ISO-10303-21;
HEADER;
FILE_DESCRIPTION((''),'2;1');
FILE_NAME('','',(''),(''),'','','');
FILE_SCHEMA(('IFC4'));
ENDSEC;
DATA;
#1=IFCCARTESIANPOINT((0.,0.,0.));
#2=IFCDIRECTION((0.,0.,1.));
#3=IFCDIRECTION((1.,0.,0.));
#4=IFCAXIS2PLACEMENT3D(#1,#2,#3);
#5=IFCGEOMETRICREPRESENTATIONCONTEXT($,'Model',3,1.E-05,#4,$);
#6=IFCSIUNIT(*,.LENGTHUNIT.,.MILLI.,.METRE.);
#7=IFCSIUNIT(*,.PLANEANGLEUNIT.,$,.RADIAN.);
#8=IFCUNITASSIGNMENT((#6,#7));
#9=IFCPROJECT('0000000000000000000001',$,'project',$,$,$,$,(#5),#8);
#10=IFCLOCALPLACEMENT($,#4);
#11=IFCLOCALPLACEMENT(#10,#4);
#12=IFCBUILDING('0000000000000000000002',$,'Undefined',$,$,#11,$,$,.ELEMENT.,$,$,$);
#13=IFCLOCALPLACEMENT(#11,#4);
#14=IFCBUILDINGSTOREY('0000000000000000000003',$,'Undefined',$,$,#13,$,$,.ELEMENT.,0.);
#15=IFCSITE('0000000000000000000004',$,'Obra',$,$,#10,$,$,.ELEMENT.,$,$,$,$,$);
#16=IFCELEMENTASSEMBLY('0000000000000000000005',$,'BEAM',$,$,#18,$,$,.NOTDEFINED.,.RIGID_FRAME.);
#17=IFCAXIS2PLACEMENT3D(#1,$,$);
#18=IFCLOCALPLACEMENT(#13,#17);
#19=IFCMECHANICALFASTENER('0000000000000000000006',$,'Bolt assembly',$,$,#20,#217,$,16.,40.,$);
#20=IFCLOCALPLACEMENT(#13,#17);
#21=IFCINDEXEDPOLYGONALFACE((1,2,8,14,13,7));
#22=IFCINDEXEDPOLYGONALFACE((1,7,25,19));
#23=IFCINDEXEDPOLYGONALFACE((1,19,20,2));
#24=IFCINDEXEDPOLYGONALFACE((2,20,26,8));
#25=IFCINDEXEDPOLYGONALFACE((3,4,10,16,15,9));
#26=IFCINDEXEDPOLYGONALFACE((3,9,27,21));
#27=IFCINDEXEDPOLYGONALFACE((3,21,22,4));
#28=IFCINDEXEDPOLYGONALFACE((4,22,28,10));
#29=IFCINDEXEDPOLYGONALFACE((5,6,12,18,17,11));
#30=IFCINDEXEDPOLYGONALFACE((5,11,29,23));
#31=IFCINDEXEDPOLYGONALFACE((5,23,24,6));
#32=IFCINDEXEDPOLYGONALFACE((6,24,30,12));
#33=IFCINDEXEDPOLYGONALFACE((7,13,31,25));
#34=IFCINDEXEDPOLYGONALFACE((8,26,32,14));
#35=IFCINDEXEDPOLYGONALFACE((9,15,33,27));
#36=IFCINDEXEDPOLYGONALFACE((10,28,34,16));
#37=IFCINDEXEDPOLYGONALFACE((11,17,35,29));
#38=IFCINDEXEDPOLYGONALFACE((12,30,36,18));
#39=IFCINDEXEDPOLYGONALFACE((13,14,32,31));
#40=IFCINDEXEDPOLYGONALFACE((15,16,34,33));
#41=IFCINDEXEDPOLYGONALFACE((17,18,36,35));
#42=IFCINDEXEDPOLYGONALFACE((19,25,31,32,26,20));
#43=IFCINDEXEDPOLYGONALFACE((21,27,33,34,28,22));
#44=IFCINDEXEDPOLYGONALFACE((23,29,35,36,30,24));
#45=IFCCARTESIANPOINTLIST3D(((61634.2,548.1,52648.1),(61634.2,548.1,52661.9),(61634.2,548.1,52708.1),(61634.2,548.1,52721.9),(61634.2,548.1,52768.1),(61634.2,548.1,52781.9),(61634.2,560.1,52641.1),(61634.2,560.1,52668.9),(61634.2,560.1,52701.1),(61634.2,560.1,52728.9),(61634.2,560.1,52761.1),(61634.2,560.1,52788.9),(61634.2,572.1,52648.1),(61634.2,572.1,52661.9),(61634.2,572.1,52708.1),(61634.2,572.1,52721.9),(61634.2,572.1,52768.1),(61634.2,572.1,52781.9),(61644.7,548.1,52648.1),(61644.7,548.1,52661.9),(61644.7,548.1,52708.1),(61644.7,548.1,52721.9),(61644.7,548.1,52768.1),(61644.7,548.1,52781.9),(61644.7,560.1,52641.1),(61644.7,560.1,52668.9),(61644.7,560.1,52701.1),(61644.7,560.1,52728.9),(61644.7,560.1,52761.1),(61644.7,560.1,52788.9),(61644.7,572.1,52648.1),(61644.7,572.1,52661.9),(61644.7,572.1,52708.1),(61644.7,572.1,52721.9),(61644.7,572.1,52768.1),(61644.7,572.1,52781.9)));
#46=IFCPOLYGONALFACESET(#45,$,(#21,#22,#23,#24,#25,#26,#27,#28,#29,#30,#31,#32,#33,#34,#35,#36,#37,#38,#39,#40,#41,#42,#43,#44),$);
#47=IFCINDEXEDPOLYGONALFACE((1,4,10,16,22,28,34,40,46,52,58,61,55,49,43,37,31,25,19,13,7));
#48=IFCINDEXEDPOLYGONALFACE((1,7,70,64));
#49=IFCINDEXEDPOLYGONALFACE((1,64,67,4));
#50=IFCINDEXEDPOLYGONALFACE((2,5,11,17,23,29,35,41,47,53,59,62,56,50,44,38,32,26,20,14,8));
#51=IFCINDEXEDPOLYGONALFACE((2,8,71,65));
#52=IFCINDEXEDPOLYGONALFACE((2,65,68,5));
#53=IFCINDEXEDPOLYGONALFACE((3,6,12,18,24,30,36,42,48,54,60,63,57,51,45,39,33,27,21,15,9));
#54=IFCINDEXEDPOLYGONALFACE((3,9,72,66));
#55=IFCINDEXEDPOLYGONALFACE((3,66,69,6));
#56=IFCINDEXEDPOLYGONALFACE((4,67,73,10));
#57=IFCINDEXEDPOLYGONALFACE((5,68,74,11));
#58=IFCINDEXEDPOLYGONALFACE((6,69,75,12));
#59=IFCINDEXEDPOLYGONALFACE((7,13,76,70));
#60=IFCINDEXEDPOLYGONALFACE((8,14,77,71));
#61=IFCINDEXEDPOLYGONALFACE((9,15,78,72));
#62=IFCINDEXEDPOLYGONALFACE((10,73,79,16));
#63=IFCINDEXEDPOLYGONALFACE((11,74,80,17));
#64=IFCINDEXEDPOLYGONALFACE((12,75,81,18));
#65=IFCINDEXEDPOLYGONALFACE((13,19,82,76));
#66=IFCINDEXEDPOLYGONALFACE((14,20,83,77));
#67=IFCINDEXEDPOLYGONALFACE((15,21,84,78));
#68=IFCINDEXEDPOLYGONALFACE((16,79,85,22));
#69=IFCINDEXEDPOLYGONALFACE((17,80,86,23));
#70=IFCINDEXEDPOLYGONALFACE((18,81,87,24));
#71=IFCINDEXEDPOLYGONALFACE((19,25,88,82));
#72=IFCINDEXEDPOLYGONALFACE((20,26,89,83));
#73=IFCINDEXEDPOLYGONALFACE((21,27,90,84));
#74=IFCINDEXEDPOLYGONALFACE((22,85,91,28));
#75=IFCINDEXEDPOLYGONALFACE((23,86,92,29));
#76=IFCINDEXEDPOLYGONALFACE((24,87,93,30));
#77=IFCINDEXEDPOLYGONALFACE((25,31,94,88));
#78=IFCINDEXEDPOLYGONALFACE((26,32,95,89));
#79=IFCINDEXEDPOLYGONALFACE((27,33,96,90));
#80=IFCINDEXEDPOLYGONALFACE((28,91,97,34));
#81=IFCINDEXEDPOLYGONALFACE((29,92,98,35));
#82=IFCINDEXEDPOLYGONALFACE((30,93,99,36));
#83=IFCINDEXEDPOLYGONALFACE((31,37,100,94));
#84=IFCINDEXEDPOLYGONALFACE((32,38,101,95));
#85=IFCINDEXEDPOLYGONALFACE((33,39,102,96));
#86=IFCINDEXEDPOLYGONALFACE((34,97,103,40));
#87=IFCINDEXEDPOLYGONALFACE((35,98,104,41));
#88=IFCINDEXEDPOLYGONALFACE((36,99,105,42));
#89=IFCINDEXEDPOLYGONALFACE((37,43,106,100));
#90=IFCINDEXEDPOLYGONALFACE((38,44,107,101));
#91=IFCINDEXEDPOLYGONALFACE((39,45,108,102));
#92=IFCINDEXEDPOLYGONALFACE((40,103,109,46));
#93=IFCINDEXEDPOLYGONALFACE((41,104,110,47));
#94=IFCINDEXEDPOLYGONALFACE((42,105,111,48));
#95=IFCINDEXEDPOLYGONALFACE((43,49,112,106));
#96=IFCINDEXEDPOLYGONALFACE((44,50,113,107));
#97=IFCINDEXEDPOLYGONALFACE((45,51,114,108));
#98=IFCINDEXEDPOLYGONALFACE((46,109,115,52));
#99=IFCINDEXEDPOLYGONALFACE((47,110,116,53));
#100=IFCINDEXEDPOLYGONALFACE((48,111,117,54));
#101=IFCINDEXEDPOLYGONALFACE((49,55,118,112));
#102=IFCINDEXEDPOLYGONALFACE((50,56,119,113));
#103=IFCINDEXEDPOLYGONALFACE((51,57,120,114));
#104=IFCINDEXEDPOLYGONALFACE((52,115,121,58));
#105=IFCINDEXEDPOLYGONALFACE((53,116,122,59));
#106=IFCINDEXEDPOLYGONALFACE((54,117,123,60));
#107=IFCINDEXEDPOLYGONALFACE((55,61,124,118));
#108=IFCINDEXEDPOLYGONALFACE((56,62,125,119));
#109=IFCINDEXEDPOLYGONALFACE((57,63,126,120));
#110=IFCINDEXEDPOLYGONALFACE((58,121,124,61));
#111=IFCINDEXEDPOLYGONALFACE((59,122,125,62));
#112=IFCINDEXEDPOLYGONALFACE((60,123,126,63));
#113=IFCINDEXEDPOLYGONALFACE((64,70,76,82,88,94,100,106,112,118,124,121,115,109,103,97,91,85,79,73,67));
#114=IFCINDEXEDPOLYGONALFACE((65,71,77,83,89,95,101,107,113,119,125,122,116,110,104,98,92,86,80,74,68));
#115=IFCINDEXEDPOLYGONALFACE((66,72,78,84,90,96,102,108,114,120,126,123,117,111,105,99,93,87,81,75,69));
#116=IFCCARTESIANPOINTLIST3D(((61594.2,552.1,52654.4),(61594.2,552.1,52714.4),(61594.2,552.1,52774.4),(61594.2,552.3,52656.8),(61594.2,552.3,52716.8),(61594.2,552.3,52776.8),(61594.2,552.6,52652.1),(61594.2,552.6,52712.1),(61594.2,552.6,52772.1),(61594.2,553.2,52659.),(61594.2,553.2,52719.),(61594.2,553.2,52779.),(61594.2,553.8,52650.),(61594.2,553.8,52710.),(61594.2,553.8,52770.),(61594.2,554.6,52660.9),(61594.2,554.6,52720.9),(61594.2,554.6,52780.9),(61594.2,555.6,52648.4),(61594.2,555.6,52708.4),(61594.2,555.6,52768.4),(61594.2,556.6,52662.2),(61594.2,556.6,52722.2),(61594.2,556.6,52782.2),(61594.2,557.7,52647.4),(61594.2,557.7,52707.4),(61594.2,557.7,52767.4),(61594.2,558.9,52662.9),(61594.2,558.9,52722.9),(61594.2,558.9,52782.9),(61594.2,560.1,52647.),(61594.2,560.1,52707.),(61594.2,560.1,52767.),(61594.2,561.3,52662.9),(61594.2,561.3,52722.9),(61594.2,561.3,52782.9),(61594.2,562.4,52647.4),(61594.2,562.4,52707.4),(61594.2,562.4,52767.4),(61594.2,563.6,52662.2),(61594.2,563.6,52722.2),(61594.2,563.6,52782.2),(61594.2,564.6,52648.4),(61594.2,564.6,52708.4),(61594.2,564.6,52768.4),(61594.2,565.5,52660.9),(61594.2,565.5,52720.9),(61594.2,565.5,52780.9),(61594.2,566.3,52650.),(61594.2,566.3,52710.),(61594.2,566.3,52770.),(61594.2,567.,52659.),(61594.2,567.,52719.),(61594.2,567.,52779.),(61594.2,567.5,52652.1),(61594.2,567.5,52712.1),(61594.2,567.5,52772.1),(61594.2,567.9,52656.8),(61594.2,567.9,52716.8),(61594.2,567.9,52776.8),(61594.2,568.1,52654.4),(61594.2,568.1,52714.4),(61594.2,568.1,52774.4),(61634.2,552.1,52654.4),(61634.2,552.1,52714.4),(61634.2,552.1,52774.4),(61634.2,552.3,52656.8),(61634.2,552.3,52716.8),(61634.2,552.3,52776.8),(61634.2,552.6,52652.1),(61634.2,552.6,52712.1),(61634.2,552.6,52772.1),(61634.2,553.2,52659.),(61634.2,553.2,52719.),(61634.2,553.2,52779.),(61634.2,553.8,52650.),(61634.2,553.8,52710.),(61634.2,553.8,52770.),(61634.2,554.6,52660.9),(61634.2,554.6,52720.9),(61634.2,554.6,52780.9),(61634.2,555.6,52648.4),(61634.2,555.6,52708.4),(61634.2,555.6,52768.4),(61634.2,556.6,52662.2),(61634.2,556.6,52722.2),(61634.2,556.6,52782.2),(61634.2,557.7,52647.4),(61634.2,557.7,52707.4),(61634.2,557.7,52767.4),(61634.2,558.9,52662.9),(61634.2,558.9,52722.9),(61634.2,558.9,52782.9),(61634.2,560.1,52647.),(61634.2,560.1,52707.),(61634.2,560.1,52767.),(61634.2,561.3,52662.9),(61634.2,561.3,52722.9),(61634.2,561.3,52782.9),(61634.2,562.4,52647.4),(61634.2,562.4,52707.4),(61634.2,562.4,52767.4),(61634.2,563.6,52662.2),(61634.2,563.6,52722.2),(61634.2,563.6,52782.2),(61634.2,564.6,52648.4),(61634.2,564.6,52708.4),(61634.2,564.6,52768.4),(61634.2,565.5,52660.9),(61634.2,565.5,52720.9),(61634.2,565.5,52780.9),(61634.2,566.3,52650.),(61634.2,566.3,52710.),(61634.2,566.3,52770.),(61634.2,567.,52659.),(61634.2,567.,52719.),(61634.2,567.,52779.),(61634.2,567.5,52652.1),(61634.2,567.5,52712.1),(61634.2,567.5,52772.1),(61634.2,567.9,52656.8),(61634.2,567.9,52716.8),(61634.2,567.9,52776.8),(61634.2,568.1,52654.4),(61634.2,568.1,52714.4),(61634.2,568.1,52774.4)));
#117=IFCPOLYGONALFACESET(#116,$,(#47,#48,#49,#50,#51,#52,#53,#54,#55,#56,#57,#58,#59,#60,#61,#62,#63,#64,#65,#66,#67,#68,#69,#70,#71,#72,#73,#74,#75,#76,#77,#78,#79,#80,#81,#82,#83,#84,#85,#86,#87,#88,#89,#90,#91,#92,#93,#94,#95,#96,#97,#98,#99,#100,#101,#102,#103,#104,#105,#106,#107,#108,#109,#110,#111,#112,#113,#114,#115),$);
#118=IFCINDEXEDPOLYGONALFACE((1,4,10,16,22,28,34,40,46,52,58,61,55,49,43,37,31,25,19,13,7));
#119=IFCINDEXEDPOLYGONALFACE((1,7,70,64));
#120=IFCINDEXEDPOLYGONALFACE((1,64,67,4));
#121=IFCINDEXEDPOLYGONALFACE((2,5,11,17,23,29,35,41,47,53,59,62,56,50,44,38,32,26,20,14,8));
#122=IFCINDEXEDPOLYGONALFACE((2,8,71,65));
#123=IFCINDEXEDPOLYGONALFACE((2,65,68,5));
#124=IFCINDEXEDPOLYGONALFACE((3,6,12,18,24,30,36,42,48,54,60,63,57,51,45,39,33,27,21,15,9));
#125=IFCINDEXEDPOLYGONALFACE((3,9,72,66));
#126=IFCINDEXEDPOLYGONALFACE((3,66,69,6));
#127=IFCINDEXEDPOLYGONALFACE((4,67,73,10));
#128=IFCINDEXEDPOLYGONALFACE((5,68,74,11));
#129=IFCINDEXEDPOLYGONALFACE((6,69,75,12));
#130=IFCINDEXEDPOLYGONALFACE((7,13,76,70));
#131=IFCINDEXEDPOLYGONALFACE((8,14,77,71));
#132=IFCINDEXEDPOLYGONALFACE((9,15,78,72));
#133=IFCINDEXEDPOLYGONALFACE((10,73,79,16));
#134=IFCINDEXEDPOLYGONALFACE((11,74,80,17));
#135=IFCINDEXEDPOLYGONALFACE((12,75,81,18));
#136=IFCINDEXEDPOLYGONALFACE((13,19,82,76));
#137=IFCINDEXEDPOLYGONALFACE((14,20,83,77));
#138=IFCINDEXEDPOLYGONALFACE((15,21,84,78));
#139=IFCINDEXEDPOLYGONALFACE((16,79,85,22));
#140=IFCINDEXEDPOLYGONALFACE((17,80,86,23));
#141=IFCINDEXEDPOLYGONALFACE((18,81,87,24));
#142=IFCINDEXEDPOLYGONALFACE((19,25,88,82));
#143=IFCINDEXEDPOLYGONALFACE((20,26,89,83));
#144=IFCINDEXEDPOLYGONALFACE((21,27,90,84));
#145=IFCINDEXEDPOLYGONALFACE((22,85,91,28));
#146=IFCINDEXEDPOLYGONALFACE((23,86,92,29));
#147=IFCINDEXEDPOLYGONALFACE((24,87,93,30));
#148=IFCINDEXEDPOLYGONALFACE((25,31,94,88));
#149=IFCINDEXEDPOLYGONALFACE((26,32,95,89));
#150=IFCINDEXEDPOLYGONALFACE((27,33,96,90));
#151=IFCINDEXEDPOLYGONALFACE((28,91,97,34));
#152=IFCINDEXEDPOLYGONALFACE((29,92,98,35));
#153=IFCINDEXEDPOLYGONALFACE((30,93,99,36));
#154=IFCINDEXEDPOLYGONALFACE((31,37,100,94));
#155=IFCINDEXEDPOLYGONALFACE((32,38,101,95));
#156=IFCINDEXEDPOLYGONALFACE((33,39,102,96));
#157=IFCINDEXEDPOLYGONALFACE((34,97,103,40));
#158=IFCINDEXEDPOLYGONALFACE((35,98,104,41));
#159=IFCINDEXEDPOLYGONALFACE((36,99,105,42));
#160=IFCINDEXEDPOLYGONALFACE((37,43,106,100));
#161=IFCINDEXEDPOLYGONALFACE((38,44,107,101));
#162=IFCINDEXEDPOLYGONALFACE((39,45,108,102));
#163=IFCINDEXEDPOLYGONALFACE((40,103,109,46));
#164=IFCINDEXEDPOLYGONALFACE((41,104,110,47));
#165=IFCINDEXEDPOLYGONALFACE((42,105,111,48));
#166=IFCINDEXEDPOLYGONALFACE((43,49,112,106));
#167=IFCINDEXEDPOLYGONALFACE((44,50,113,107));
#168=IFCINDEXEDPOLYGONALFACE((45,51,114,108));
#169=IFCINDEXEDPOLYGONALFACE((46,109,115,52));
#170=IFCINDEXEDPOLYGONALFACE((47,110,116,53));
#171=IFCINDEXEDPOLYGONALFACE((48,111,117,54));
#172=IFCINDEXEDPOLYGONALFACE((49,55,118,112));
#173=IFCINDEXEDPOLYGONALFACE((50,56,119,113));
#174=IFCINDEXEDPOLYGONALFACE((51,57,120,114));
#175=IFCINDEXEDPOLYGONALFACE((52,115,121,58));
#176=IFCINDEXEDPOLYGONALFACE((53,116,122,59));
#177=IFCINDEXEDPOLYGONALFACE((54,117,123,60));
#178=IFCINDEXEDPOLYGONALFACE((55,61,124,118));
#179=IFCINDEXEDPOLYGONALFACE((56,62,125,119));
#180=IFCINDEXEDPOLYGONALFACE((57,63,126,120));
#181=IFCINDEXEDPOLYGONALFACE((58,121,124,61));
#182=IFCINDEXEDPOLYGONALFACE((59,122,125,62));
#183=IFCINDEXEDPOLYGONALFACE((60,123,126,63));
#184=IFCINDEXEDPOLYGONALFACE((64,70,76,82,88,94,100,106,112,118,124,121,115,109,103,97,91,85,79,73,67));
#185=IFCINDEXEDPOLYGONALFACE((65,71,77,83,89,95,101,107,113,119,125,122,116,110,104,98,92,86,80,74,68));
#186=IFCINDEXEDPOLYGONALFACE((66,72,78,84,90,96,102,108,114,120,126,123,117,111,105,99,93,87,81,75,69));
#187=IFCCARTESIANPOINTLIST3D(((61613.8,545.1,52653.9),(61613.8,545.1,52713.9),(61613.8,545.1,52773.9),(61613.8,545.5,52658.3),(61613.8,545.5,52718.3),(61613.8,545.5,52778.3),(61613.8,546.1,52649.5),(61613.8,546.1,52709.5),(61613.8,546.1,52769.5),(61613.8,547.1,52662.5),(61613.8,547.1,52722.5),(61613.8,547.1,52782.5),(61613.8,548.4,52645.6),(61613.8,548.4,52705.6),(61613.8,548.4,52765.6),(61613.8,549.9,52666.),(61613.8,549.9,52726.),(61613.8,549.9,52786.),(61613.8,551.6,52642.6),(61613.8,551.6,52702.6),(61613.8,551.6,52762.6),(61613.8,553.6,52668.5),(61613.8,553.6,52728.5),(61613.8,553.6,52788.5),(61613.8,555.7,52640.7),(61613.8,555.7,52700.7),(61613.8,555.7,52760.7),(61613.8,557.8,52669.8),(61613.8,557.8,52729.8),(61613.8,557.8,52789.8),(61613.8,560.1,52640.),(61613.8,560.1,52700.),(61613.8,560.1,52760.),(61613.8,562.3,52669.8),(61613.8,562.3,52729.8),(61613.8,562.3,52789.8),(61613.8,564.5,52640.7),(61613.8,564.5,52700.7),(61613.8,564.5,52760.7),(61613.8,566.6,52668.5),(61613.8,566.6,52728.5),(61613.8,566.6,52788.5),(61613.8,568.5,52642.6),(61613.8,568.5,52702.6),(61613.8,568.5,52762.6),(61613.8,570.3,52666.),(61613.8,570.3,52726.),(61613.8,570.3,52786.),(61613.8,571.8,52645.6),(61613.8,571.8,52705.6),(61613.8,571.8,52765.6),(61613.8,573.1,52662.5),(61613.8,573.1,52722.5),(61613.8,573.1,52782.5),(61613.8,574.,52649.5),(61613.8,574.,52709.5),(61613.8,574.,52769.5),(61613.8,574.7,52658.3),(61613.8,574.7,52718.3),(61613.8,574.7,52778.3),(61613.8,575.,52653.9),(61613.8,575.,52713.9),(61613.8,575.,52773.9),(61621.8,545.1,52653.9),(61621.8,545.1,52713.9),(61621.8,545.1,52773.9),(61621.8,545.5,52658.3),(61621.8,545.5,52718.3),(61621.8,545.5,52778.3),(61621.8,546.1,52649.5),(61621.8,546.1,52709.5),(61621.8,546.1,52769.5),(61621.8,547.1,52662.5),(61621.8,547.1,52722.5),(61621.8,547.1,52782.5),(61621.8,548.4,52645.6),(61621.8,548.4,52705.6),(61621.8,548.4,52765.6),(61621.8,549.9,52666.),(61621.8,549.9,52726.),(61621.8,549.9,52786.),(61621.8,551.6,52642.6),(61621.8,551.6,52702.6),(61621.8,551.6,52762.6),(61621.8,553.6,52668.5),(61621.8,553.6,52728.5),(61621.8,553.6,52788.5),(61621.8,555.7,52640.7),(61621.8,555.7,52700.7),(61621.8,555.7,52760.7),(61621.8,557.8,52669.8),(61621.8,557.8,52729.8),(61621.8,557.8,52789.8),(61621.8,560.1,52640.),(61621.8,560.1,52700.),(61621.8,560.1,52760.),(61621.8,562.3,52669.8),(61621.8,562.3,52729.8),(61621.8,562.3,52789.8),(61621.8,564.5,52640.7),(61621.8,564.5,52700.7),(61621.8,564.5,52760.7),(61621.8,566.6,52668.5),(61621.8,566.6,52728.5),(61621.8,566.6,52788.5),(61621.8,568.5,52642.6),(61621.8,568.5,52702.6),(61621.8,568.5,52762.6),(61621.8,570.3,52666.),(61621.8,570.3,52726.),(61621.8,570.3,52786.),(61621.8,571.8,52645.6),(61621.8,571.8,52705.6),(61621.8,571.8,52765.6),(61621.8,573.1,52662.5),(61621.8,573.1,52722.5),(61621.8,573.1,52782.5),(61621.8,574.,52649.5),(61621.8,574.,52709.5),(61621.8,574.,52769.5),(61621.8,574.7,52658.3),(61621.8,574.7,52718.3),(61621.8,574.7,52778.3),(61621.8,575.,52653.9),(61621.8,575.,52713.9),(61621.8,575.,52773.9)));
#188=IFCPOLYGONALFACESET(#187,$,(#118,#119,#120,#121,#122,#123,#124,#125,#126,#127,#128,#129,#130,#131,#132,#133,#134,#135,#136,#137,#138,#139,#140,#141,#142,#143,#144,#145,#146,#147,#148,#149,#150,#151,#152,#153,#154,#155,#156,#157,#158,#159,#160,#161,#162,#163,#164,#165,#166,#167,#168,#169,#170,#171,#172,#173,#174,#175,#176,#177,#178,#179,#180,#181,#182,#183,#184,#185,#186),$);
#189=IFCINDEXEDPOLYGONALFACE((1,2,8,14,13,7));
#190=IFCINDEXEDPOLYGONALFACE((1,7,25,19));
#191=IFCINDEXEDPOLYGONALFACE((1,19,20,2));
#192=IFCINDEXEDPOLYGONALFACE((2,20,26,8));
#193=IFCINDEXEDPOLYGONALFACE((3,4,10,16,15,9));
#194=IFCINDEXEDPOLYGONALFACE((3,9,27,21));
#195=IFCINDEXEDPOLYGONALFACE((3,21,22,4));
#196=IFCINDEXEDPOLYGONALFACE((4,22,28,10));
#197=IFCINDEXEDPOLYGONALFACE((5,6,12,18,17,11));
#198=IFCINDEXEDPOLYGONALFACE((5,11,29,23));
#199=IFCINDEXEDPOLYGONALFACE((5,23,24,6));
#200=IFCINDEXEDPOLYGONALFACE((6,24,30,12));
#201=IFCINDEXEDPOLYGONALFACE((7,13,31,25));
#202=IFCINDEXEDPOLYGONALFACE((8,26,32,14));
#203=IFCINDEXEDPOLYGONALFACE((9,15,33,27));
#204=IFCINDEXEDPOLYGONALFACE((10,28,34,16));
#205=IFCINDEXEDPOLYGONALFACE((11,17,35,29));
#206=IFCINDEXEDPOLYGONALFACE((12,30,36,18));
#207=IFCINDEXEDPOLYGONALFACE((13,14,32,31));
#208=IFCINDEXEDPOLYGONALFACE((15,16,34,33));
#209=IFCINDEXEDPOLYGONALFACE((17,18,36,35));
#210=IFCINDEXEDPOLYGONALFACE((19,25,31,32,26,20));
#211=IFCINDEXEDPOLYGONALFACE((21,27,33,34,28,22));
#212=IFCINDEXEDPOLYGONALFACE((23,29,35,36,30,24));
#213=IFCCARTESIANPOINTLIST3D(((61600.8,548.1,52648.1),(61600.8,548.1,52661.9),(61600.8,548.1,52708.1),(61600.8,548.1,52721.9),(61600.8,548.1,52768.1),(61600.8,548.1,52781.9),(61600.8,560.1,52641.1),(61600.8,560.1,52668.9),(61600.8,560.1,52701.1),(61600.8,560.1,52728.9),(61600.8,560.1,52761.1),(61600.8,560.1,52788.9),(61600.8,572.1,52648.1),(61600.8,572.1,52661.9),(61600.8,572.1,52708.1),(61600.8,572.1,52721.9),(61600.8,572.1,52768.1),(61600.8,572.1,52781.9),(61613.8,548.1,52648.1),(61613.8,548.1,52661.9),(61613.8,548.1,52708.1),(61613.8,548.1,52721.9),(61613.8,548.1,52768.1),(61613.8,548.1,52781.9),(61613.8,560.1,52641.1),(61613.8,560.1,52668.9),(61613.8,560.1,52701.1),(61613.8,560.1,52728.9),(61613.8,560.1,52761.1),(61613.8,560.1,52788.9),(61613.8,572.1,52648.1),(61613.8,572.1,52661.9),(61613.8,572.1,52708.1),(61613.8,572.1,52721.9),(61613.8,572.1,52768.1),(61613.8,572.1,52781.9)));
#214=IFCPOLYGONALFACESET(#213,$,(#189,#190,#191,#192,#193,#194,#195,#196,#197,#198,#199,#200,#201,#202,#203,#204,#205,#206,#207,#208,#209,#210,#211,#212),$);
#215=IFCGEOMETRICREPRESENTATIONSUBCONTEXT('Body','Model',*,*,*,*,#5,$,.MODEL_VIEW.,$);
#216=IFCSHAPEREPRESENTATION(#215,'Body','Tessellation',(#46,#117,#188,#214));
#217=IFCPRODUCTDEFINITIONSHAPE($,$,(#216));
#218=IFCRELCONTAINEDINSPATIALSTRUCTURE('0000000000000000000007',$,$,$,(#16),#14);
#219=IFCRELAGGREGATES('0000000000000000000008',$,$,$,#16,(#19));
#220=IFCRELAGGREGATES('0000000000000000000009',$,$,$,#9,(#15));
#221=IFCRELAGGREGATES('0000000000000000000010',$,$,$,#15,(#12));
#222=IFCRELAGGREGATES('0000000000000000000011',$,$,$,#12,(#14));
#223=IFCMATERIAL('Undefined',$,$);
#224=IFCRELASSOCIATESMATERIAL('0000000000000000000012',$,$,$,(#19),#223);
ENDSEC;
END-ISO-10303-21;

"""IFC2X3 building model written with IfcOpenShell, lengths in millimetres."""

from ifc_helpers import new_model, si_unit, frame, origin_with_axes, origin_2d_with_axis, place, context, subcontext, project, spatial, polyline, circle, outline, extrude, source, transform, mapped, material, element, aggregate, save


model = new_model("IFC2X3")

# Units and contexts
model_context = context("Model", 3, precision=1e-05, world=origin_with_axes())
body_context = subcontext(model_context, "Body", "Model", "MODEL_VIEW")
ifc_project = project(units=[si_unit("LENGTHUNIT", "METRE", prefix="MILLI"), si_unit("PLANEANGLEUNIT", "RADIAN")], contexts=[model_context])

# Site, building, storey
site_placement = place(None, origin_with_axes())
site = spatial("IfcSite", under=ifc_project, at=site_placement, Name="Obra", CompositionType="ELEMENT")
building_placement = place(site_placement, origin_with_axes())
building = spatial("IfcBuilding", under=site, at=building_placement, Name="Undefined", CompositionType="ELEMENT")
storey_placement = place(building_placement, origin_with_axes())
storey = spatial("IfcBuildingStorey", under=building, at=storey_placement, Name="Undefined", CompositionType="ELEMENT", Elevation=0.0)

# Shared definitions
ifc_material_1 = material(Name="Undefined")
shared_shape_1 = source(origin_with_axes(), body_context, "Body", "SweptSolid", [
    extrude(outline(polyline([(13.9, 0.0), (6.9, 12.0), (-6.9, 12.0), (-13.9, 0.0), (-6.9, -12.0), (6.9, -12.0), (13.9, 0.0)])), frame((0.0, -19.7, 0.0), z_axis=(0.0, 1.0, 0.0), x_axis=(1.0, 0.0, 0.0)), (0.0, 0.0, 1.0), 10.6),
    extrude(circle(Radius=8.0, at=origin_2d_with_axis()), frame((0.0, -9.1, 0.0), z_axis=(0.0, 1.0, 0.0), x_axis=(1.0, 0.0, 0.0)), (0.0, 0.0, 1.0), 40.0),
    extrude(circle(Radius=15.0, at=origin_2d_with_axis()), frame((0.0, 3.3, 0.0), z_axis=(0.0, 1.0, 0.0), x_axis=(1.0, 0.0, 0.0)), (0.0, 0.0, 1.0), 8.0),
    extrude(outline(polyline([(13.9, 0.0), (6.9, 12.0), (-6.9, 12.0), (-13.9, 0.0), (-6.9, -12.0), (6.9, -12.0), (13.9, 0.0)])), frame((0.0, 11.3, 0.0), z_axis=(0.0, 1.0, 0.0), x_axis=(1.0, 0.0, 0.0)), (0.0, 0.0, 1.0), 13.0),
])

# Element assembly, mechanical fastener
assembly_1_placement = place(storey_placement, origin_with_axes())
assembly_1 = element("IfcElementAssembly", 1, at=assembly_1_placement, inside=storey, Name="BEAM", AssemblyPlace="NOTDEFINED", PredefinedType="RIGID_FRAME")
mechanical_fastener_1_placement = place(assembly_1_placement, frame((61625.1, 510.1, 52835.0), z_axis=(-0.000002, 1.0, 0.0), x_axis=(0.0, 0.0, -1.0)))
mechanical_fastener_1 = element("IfcMechanicalFastener", 2, at=mechanical_fastener_1_placement, material=ifc_material_1, Name="Bolt assembly", NominalDiameter=16.0, NominalLength=40.0, context=body_context, shape_type="MappedRepresentation", body=[
    mapped(shared_shape_1, transform((60.0, 0.0, 50.0))),
    mapped(shared_shape_1, transform((120.0, 0.0, 50.0))),
    mapped(shared_shape_1, transform((180.0, 0.0, 50.0))),
])
aggregate(assembly_1, [mechanical_fastener_1])

save(model, "model.ifc")
